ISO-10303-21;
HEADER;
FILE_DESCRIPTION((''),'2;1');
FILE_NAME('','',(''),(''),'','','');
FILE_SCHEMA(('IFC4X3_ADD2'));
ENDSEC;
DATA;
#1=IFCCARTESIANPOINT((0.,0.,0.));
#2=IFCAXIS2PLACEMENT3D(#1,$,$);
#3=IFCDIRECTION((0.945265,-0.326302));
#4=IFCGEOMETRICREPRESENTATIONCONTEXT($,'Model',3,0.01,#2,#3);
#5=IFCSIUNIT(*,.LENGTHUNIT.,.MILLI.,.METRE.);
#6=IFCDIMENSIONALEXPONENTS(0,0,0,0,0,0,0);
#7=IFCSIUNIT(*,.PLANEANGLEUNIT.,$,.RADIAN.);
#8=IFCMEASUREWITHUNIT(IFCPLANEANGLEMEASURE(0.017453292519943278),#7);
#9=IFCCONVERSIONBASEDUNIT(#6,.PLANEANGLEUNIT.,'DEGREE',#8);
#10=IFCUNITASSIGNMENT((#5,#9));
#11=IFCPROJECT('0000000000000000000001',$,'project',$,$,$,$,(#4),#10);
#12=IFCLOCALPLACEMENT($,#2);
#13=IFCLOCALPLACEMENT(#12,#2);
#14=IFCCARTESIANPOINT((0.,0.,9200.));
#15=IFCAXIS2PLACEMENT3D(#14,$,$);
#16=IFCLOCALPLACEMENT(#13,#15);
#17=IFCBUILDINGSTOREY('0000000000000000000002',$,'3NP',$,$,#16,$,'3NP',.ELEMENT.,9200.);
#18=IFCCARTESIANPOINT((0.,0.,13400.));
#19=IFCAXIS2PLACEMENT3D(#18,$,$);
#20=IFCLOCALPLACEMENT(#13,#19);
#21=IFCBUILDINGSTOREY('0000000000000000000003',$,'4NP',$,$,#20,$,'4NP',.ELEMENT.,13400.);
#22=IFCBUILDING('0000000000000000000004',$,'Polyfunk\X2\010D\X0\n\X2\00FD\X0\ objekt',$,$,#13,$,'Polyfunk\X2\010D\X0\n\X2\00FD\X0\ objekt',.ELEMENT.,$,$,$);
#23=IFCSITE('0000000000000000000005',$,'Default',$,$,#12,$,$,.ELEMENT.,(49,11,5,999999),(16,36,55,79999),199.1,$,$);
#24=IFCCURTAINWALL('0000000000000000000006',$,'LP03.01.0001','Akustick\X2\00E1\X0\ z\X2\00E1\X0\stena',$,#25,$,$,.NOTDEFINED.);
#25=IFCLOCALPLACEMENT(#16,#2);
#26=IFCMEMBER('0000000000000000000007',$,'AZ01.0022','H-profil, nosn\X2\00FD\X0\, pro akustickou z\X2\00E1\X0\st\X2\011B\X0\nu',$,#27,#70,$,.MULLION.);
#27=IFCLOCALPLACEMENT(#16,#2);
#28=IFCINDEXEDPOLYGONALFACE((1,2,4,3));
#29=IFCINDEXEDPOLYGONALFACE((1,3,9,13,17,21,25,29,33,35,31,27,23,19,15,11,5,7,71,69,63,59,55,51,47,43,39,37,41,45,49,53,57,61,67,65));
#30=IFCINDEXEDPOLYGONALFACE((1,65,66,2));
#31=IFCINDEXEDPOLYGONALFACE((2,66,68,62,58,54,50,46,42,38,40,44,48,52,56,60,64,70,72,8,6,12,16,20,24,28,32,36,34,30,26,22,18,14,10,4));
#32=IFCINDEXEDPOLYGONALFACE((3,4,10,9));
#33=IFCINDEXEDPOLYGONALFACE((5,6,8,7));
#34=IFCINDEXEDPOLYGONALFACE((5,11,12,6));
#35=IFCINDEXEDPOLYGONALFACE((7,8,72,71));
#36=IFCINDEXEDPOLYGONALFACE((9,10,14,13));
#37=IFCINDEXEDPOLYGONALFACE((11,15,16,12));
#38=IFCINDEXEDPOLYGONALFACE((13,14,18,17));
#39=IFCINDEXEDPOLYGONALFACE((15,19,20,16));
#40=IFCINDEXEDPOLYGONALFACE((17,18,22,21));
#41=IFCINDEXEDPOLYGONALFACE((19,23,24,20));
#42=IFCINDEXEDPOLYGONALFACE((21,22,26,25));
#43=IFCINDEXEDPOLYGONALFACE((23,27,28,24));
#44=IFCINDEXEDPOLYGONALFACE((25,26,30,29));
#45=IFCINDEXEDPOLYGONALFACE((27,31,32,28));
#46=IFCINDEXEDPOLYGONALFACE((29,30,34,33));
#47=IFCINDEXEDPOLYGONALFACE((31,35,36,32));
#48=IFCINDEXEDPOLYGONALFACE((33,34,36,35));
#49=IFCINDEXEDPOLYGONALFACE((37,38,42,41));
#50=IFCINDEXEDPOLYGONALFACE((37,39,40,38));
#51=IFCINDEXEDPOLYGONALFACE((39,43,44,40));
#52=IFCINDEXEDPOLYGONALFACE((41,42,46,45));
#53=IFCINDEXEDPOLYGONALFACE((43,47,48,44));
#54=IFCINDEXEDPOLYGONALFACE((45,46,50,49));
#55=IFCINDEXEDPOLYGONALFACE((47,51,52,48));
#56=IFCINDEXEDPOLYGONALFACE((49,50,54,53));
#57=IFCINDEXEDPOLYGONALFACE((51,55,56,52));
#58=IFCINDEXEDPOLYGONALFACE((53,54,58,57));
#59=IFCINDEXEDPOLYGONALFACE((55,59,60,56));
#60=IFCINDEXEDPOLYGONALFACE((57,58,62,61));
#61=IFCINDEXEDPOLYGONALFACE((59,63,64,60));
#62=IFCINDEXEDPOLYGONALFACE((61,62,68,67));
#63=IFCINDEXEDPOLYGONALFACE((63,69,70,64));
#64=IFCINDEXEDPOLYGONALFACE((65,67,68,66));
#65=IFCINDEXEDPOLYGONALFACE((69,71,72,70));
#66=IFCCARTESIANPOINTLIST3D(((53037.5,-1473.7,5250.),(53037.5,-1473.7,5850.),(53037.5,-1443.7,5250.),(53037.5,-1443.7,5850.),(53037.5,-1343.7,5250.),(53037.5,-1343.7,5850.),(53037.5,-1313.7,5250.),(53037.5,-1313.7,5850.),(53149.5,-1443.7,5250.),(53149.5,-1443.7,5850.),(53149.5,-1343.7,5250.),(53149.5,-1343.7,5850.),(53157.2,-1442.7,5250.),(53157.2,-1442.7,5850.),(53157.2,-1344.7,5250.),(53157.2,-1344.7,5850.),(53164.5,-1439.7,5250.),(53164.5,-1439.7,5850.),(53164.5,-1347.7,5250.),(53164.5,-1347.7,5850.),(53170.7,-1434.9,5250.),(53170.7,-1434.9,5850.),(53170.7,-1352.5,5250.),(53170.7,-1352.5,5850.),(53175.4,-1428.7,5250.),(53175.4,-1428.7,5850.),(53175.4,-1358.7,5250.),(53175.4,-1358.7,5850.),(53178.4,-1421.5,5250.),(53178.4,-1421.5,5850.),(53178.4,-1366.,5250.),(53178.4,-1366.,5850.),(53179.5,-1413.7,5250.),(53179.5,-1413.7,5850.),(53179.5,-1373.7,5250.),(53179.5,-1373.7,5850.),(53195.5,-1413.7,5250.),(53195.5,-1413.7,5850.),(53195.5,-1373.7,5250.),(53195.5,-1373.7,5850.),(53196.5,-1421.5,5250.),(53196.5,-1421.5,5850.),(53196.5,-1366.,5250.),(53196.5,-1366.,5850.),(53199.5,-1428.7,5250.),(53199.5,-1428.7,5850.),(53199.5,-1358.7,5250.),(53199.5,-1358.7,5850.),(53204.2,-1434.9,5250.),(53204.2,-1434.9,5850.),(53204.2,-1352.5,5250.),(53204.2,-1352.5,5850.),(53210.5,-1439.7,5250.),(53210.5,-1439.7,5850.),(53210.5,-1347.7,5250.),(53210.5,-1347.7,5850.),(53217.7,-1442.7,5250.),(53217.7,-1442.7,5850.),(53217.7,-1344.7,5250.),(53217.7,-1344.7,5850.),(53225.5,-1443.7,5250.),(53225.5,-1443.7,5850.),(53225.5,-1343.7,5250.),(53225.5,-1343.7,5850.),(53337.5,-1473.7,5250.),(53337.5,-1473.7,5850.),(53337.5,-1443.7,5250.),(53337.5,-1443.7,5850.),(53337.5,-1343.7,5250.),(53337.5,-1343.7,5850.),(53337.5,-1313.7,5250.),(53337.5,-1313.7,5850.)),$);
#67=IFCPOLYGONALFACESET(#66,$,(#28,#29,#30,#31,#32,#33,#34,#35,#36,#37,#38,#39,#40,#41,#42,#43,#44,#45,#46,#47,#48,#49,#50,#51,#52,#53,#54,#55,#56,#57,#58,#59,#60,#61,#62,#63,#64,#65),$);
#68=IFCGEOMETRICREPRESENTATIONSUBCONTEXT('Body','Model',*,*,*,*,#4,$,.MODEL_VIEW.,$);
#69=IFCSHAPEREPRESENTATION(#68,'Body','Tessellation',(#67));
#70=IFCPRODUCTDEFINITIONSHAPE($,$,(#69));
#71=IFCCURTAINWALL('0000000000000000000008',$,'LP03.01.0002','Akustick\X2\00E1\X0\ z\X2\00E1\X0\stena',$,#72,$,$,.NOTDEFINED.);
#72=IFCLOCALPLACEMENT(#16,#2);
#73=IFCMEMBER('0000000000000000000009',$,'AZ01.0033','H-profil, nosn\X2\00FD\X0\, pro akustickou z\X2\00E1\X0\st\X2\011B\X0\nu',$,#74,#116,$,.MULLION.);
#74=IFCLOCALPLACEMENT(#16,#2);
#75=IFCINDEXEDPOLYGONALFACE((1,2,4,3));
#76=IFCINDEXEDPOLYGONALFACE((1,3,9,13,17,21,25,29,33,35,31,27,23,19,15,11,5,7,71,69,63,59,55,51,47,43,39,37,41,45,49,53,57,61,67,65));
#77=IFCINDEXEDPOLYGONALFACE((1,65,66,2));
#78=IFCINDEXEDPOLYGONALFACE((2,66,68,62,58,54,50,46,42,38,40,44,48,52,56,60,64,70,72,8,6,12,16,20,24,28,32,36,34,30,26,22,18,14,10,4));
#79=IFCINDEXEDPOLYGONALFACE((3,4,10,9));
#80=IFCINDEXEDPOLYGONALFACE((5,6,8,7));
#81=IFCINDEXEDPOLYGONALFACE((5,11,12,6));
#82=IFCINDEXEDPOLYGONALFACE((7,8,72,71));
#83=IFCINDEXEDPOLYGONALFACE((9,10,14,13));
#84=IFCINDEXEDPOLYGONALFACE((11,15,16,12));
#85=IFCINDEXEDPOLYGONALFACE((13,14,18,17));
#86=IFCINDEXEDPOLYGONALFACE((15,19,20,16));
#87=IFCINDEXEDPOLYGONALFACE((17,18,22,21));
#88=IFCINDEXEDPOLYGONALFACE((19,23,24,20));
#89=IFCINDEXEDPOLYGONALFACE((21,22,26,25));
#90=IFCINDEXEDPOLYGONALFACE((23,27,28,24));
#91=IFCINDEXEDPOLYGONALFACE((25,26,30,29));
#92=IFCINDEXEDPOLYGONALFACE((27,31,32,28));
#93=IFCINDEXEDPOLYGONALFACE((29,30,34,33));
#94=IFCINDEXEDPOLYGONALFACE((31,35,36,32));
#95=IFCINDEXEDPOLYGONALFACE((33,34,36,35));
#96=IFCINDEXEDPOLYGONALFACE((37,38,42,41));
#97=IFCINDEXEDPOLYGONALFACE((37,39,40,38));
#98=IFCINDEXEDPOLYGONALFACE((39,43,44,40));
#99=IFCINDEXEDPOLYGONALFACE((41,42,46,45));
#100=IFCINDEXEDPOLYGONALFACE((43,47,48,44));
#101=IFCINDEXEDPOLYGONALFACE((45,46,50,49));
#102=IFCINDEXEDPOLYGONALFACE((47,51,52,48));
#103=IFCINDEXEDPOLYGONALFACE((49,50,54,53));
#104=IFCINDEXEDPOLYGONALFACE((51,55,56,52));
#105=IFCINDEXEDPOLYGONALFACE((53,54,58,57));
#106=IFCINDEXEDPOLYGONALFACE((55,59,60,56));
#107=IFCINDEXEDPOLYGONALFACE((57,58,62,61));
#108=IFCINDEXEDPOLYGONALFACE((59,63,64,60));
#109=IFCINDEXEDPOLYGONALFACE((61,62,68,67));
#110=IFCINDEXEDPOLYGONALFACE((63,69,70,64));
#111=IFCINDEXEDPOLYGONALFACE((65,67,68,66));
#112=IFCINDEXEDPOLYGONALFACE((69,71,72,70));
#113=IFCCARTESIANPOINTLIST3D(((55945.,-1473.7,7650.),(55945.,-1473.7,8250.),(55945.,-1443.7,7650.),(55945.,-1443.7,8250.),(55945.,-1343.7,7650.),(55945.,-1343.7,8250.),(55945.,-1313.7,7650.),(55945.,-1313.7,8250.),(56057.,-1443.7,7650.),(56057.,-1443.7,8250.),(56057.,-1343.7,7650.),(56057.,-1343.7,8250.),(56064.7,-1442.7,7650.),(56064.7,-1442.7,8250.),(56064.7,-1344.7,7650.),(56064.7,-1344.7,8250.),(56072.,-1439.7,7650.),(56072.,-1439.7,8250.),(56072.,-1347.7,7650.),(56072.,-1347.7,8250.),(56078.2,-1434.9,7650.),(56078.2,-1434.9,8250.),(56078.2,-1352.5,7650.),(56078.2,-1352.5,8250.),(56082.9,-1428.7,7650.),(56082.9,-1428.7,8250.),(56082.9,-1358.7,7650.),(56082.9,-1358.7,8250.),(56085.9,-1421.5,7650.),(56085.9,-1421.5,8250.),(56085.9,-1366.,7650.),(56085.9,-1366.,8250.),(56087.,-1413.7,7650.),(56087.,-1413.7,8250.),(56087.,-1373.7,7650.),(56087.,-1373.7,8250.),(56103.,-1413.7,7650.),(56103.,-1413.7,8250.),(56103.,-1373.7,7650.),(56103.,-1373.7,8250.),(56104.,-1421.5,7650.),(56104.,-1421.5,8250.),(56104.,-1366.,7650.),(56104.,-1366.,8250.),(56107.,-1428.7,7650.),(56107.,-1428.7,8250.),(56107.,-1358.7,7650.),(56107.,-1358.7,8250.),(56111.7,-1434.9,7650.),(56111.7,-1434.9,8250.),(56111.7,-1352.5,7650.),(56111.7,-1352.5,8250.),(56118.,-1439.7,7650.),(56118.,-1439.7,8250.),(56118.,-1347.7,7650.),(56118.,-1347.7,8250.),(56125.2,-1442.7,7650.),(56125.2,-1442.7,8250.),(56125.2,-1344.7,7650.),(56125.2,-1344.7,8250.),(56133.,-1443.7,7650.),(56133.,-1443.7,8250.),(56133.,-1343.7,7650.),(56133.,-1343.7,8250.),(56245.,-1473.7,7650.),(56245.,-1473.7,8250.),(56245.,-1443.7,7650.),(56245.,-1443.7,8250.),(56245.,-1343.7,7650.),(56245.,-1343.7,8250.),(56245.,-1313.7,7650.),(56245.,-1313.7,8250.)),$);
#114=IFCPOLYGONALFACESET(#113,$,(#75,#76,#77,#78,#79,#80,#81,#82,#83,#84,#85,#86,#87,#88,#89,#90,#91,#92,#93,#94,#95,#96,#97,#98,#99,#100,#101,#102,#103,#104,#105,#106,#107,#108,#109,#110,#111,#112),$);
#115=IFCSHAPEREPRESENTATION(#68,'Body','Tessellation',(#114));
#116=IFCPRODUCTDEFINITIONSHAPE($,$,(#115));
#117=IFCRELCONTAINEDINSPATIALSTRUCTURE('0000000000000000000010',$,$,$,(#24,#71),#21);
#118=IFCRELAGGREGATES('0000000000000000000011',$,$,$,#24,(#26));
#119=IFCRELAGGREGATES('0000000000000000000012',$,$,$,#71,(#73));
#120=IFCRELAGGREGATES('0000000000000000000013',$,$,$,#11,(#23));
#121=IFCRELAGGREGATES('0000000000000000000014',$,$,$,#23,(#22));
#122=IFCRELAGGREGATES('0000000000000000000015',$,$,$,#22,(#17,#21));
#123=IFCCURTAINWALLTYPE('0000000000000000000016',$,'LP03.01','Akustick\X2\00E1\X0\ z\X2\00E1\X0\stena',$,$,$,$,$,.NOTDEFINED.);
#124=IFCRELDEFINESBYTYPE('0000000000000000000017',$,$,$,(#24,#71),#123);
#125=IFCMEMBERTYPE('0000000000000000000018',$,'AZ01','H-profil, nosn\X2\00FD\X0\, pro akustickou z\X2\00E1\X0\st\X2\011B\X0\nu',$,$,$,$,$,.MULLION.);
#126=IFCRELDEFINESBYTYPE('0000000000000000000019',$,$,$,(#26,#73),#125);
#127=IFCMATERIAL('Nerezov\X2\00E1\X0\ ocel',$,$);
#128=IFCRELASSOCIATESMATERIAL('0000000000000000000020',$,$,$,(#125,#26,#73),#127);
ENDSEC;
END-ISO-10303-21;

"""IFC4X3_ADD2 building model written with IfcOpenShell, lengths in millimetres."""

from ifc_helpers import new_model, entity, si_unit, converted_unit, direction, frame, frame_2d, origin, place, context, subcontext, project, spatial, polyline, circle_curve, parameter, trimmed, segment, composite_curve, outline, extrude, source, transform, mapped, material, material_profile, profile_set, profile_usage, type_object, element, aggregate, save


model = new_model("IFC4X3_ADD2")

# Units and contexts
model_context = context("Model", 3, precision=0.01, world=origin(), true_north=direction((0.945265, -0.326302)))
body_context = subcontext(model_context, "Body", "Model", "MODEL_VIEW")
ifc_project = project(units=[si_unit("LENGTHUNIT", "METRE", prefix="MILLI"), converted_unit("PLANEANGLEUNIT", "DEGREE", entity("IfcPlaneAngleMeasure", 0.017453292519943278), si_unit("PLANEANGLEUNIT", "RADIAN"), dimensions=[0, 0, 0, 0, 0, 0, 0])], contexts=[model_context])

# Site, building, storey
site_placement = place(None, origin())
site = spatial("IfcSite", under=ifc_project, at=site_placement, Name="Default", CompositionType="ELEMENT", RefLatitude=(49, 11, 5, 999999), RefLongitude=(16, 36, 55, 79999), RefElevation=199.1)
building_placement = place(site_placement, origin())
building = spatial("IfcBuilding", under=site, at=building_placement, Name="Polyfunkčný objekt", LongName="Polyfunkčný objekt", CompositionType="ELEMENT")
storey_1_placement = place(building_placement, frame((0.0, 0.0, 9200.0)))
storey_1 = spatial("IfcBuildingStorey", under=building, at=storey_1_placement, Name="3NP", LongName="3NP", CompositionType="ELEMENT", Elevation=9200.0)

# Shared definitions
storey_2_placement = place(building_placement, frame((0.0, 0.0, 13400.0)))
storey_2 = spatial("IfcBuildingStorey", under=building, at=storey_2_placement, Name="4NP", LongName="4NP", CompositionType="ELEMENT", Elevation=13400.0)

# Curtain walls, members
curtain_wall_type_1 = type_object("IfcCurtainWallType", Name="LP03.01", Description="Akustická zástena", PredefinedType="NOTDEFINED")
curtain_wall_1_placement = place(storey_2_placement, frame((0.0, 0.0, -13400.0)))
curtain_wall_1 = element("IfcCurtainWall", 1, at=curtain_wall_1_placement, inside=storey_2, type_object=curtain_wall_type_1, Name="LP03.01.0001", Description="Akustická zástena", PredefinedType="NOTDEFINED")
ifc_material_1 = material(Name="Nerezová ocel")
ifc_material_profile_1 = material_profile(ifc_material_1, outline(composite_curve([segment(polyline([(50.0, -150.0), (80.0, -150.0)]), True, "CONTINUOUS"), segment(polyline([(80.0, -150.0), (80.0, 150.0)]), True, "CONTINUOUS"), segment(polyline([(80.0, 150.0), (50.0, 150.0)]), True, "CONTINUOUS"), segment(polyline([(50.0, 150.0), (50.0, 38.0)]), True, "CONTINUOUS"), segment(trimmed(circle_curve(frame_2d((20.0, 38.0), x_axis=(0.0, 1.0)), 30.0), [parameter(180.0)], [parameter(270.0)], True, "PARAMETER"), False, "CONTINUOUS"), segment(polyline([(20.0, 8.0), (-20.0, 8.0)]), True, "CONTINUOUS"), segment(trimmed(circle_curve(frame_2d((-20.0, 38.0), x_axis=(0.0, 1.0)), 30.0), [parameter(90.0)], [parameter(180.0)], True, "PARAMETER"), False, "CONTINUOUS"), segment(polyline([(-50.0, 38.0), (-50.0, 150.0)]), True, "CONTINUOUS"), segment(polyline([(-50.0, 150.0), (-80.0, 150.0)]), True, "CONTINUOUS"), segment(polyline([(-80.0, 150.0), (-80.0, -150.0)]), True, "CONTINUOUS"), segment(polyline([(-80.0, -150.0), (-50.0, -150.0)]), True, "CONTINUOUS"), segment(polyline([(-50.0, -150.0), (-50.0, -38.0)]), True, "CONTINUOUS"), segment(trimmed(circle_curve(frame_2d((-20.0, -38.0), x_axis=(0.0, 1.0)), 30.0), [parameter(0.0)], [parameter(90.0)], True, "PARAMETER"), False, "CONTINUOUS"), segment(polyline([(-20.0, -8.0), (20.0, -8.0)]), True, "CONTINUOUS"), segment(trimmed(circle_curve(frame_2d((20.0, -38.0), x_axis=(0.0, 1.0)), 30.0), [parameter(270.0)], [parameter(0.0)], True, "PARAMETER"), False, "CONTINUOUS"), segment(polyline([(50.0, -38.0), (50.0, -150.0)]), True, "CONTINUOUS")], self_intersect=False)), Name="Profil zástena")
ifc_profile_set_1 = profile_set([ifc_material_profile_1], Name="Profil zástena")
ifc_profile_usage_1 = profile_usage(ifc_profile_set_1)
member_type_1 = type_object("IfcMemberType", Name="AZ01", Description="H-profil, nosný, pro akustickou zástěnu", PredefinedType="MULLION", material=ifc_profile_set_1)
shared_shape_1 = source(origin(), body_context, "Body", "SweptSolid", [
    extrude(outline(composite_curve([segment(polyline([(50.0, -150.0), (80.0, -150.0)]), True, "CONTINUOUS"), segment(polyline([(80.0, -150.0), (80.0, 150.0)]), True, "CONTINUOUS"), segment(polyline([(80.0, 150.0), (50.0, 150.0)]), True, "CONTINUOUS"), segment(polyline([(50.0, 150.0), (50.0, 38.0)]), True, "CONTINUOUS"), segment(trimmed(circle_curve(frame_2d((20.0, 38.0), x_axis=(0.0, 1.0)), 30.0), [parameter(180.0)], [parameter(270.0)], True, "PARAMETER"), False, "CONTINUOUS"), segment(polyline([(20.0, 8.0), (-20.0, 8.0)]), True, "CONTINUOUS"), segment(trimmed(circle_curve(frame_2d((-20.0, 38.0), x_axis=(0.0, 1.0)), 30.0), [parameter(90.0)], [parameter(180.0)], True, "PARAMETER"), False, "CONTINUOUS"), segment(polyline([(-50.0, 38.0), (-50.0, 150.0)]), True, "CONTINUOUS"), segment(polyline([(-50.0, 150.0), (-80.0, 150.0)]), True, "CONTINUOUS"), segment(polyline([(-80.0, 150.0), (-80.0, -150.0)]), True, "CONTINUOUS"), segment(polyline([(-80.0, -150.0), (-50.0, -150.0)]), True, "CONTINUOUS"), segment(polyline([(-50.0, -150.0), (-50.0, -38.0)]), True, "CONTINUOUS"), segment(trimmed(circle_curve(frame_2d((-20.0, -38.0), x_axis=(0.0, 1.0)), 30.0), [parameter(0.0)], [parameter(90.0)], True, "PARAMETER"), False, "CONTINUOUS"), segment(polyline([(-20.0, -8.0), (20.0, -8.0)]), True, "CONTINUOUS"), segment(trimmed(circle_curve(frame_2d((20.0, -38.0), x_axis=(0.0, 1.0)), 30.0), [parameter(270.0)], [parameter(0.0)], True, "PARAMETER"), False, "CONTINUOUS"), segment(polyline([(50.0, -38.0), (50.0, -150.0)]), True, "CONTINUOUS")], self_intersect=False)), frame((0.0, 0.0, -600.0), z_axis=(0.0, 0.0, 1.0), x_axis=(0.0, -1.0, 0.0)), (0.0, 0.0, 1.0), 600.0),
])
member_1_placement = place(curtain_wall_1_placement, frame((53187.5, -1393.7, 14450.0), z_axis=(0.0, 0.0, -1.0), x_axis=(1.0, 0.0, 0.0)))
member_1 = element("IfcMember", 2, at=member_1_placement, type_object=member_type_1, material=ifc_profile_usage_1, Name="AZ01.0022", Description="H-profil, nosný, pro akustickou zástěnu", PredefinedType="MULLION", context=body_context, shape_type="MappedRepresentation", body=[
    mapped(shared_shape_1, transform((0.0, 0.0, 0.0), scale=1.0)),
])
aggregate(curtain_wall_1, [member_1])
curtain_wall_2_placement = place(storey_2_placement, frame((0.0, 0.0, -13400.0)))
curtain_wall_2 = element("IfcCurtainWall", 3, at=curtain_wall_2_placement, inside=storey_2, type_object=curtain_wall_type_1, Name="LP03.01.0002", Description="Akustická zástena", PredefinedType="NOTDEFINED")
shared_shape_2 = source(origin(), body_context, "Body", "SweptSolid", [
    extrude(outline(composite_curve([segment(polyline([(50.0, -150.0), (80.0, -150.0)]), True, "CONTINUOUS"), segment(polyline([(80.0, -150.0), (80.0, 150.0)]), True, "CONTINUOUS"), segment(polyline([(80.0, 150.0), (50.0, 150.0)]), True, "CONTINUOUS"), segment(polyline([(50.0, 150.0), (50.0, 38.0)]), True, "CONTINUOUS"), segment(trimmed(circle_curve(frame_2d((20.0, 38.0), x_axis=(0.0, 1.0)), 30.0), [parameter(180.0)], [parameter(270.0)], True, "PARAMETER"), False, "CONTINUOUS"), segment(polyline([(20.0, 8.0), (-20.0, 8.0)]), True, "CONTINUOUS"), segment(trimmed(circle_curve(frame_2d((-20.0, 38.0), x_axis=(0.0, 1.0)), 30.0), [parameter(90.0)], [parameter(180.0)], True, "PARAMETER"), False, "CONTINUOUS"), segment(polyline([(-50.0, 38.0), (-50.0, 150.0)]), True, "CONTINUOUS"), segment(polyline([(-50.0, 150.0), (-80.0, 150.0)]), True, "CONTINUOUS"), segment(polyline([(-80.0, 150.0), (-80.0, -150.0)]), True, "CONTINUOUS"), segment(polyline([(-80.0, -150.0), (-50.0, -150.0)]), True, "CONTINUOUS"), segment(polyline([(-50.0, -150.0), (-50.0, -38.0)]), True, "CONTINUOUS"), segment(trimmed(circle_curve(frame_2d((-20.0, -38.0), x_axis=(0.0, 1.0)), 30.0), [parameter(0.0)], [parameter(90.0)], True, "PARAMETER"), False, "CONTINUOUS"), segment(polyline([(-20.0, -8.0), (20.0, -8.0)]), True, "CONTINUOUS"), segment(trimmed(circle_curve(frame_2d((20.0, -38.0), x_axis=(0.0, 1.0)), 30.0), [parameter(270.0)], [parameter(0.0)], True, "PARAMETER"), False, "CONTINUOUS"), segment(polyline([(50.0, -38.0), (50.0, -150.0)]), True, "CONTINUOUS")], self_intersect=False)), frame((-150.0, 0.0, -600.0), z_axis=(0.0, 0.0, 1.0), x_axis=(0.0, -1.0, 0.0)), (0.0, 0.0, 1.0), 600.0),
])
member_2_placement = place(curtain_wall_2_placement, frame((56245.0, -1393.7, 16850.0), z_axis=(0.0, 0.0, -1.0), x_axis=(1.0, 0.0, 0.0)))
member_2 = element("IfcMember", 4, at=member_2_placement, type_object=member_type_1, material=ifc_profile_usage_1, Name="AZ01.0033", Description="H-profil, nosný, pro akustickou zástěnu", PredefinedType="MULLION", context=body_context, shape_type="MappedRepresentation", body=[
    mapped(shared_shape_2, transform((0.0, 0.0, 0.0), scale=1.0)),
])
aggregate(curtain_wall_2, [member_2])

save(model, "model.ifc")
